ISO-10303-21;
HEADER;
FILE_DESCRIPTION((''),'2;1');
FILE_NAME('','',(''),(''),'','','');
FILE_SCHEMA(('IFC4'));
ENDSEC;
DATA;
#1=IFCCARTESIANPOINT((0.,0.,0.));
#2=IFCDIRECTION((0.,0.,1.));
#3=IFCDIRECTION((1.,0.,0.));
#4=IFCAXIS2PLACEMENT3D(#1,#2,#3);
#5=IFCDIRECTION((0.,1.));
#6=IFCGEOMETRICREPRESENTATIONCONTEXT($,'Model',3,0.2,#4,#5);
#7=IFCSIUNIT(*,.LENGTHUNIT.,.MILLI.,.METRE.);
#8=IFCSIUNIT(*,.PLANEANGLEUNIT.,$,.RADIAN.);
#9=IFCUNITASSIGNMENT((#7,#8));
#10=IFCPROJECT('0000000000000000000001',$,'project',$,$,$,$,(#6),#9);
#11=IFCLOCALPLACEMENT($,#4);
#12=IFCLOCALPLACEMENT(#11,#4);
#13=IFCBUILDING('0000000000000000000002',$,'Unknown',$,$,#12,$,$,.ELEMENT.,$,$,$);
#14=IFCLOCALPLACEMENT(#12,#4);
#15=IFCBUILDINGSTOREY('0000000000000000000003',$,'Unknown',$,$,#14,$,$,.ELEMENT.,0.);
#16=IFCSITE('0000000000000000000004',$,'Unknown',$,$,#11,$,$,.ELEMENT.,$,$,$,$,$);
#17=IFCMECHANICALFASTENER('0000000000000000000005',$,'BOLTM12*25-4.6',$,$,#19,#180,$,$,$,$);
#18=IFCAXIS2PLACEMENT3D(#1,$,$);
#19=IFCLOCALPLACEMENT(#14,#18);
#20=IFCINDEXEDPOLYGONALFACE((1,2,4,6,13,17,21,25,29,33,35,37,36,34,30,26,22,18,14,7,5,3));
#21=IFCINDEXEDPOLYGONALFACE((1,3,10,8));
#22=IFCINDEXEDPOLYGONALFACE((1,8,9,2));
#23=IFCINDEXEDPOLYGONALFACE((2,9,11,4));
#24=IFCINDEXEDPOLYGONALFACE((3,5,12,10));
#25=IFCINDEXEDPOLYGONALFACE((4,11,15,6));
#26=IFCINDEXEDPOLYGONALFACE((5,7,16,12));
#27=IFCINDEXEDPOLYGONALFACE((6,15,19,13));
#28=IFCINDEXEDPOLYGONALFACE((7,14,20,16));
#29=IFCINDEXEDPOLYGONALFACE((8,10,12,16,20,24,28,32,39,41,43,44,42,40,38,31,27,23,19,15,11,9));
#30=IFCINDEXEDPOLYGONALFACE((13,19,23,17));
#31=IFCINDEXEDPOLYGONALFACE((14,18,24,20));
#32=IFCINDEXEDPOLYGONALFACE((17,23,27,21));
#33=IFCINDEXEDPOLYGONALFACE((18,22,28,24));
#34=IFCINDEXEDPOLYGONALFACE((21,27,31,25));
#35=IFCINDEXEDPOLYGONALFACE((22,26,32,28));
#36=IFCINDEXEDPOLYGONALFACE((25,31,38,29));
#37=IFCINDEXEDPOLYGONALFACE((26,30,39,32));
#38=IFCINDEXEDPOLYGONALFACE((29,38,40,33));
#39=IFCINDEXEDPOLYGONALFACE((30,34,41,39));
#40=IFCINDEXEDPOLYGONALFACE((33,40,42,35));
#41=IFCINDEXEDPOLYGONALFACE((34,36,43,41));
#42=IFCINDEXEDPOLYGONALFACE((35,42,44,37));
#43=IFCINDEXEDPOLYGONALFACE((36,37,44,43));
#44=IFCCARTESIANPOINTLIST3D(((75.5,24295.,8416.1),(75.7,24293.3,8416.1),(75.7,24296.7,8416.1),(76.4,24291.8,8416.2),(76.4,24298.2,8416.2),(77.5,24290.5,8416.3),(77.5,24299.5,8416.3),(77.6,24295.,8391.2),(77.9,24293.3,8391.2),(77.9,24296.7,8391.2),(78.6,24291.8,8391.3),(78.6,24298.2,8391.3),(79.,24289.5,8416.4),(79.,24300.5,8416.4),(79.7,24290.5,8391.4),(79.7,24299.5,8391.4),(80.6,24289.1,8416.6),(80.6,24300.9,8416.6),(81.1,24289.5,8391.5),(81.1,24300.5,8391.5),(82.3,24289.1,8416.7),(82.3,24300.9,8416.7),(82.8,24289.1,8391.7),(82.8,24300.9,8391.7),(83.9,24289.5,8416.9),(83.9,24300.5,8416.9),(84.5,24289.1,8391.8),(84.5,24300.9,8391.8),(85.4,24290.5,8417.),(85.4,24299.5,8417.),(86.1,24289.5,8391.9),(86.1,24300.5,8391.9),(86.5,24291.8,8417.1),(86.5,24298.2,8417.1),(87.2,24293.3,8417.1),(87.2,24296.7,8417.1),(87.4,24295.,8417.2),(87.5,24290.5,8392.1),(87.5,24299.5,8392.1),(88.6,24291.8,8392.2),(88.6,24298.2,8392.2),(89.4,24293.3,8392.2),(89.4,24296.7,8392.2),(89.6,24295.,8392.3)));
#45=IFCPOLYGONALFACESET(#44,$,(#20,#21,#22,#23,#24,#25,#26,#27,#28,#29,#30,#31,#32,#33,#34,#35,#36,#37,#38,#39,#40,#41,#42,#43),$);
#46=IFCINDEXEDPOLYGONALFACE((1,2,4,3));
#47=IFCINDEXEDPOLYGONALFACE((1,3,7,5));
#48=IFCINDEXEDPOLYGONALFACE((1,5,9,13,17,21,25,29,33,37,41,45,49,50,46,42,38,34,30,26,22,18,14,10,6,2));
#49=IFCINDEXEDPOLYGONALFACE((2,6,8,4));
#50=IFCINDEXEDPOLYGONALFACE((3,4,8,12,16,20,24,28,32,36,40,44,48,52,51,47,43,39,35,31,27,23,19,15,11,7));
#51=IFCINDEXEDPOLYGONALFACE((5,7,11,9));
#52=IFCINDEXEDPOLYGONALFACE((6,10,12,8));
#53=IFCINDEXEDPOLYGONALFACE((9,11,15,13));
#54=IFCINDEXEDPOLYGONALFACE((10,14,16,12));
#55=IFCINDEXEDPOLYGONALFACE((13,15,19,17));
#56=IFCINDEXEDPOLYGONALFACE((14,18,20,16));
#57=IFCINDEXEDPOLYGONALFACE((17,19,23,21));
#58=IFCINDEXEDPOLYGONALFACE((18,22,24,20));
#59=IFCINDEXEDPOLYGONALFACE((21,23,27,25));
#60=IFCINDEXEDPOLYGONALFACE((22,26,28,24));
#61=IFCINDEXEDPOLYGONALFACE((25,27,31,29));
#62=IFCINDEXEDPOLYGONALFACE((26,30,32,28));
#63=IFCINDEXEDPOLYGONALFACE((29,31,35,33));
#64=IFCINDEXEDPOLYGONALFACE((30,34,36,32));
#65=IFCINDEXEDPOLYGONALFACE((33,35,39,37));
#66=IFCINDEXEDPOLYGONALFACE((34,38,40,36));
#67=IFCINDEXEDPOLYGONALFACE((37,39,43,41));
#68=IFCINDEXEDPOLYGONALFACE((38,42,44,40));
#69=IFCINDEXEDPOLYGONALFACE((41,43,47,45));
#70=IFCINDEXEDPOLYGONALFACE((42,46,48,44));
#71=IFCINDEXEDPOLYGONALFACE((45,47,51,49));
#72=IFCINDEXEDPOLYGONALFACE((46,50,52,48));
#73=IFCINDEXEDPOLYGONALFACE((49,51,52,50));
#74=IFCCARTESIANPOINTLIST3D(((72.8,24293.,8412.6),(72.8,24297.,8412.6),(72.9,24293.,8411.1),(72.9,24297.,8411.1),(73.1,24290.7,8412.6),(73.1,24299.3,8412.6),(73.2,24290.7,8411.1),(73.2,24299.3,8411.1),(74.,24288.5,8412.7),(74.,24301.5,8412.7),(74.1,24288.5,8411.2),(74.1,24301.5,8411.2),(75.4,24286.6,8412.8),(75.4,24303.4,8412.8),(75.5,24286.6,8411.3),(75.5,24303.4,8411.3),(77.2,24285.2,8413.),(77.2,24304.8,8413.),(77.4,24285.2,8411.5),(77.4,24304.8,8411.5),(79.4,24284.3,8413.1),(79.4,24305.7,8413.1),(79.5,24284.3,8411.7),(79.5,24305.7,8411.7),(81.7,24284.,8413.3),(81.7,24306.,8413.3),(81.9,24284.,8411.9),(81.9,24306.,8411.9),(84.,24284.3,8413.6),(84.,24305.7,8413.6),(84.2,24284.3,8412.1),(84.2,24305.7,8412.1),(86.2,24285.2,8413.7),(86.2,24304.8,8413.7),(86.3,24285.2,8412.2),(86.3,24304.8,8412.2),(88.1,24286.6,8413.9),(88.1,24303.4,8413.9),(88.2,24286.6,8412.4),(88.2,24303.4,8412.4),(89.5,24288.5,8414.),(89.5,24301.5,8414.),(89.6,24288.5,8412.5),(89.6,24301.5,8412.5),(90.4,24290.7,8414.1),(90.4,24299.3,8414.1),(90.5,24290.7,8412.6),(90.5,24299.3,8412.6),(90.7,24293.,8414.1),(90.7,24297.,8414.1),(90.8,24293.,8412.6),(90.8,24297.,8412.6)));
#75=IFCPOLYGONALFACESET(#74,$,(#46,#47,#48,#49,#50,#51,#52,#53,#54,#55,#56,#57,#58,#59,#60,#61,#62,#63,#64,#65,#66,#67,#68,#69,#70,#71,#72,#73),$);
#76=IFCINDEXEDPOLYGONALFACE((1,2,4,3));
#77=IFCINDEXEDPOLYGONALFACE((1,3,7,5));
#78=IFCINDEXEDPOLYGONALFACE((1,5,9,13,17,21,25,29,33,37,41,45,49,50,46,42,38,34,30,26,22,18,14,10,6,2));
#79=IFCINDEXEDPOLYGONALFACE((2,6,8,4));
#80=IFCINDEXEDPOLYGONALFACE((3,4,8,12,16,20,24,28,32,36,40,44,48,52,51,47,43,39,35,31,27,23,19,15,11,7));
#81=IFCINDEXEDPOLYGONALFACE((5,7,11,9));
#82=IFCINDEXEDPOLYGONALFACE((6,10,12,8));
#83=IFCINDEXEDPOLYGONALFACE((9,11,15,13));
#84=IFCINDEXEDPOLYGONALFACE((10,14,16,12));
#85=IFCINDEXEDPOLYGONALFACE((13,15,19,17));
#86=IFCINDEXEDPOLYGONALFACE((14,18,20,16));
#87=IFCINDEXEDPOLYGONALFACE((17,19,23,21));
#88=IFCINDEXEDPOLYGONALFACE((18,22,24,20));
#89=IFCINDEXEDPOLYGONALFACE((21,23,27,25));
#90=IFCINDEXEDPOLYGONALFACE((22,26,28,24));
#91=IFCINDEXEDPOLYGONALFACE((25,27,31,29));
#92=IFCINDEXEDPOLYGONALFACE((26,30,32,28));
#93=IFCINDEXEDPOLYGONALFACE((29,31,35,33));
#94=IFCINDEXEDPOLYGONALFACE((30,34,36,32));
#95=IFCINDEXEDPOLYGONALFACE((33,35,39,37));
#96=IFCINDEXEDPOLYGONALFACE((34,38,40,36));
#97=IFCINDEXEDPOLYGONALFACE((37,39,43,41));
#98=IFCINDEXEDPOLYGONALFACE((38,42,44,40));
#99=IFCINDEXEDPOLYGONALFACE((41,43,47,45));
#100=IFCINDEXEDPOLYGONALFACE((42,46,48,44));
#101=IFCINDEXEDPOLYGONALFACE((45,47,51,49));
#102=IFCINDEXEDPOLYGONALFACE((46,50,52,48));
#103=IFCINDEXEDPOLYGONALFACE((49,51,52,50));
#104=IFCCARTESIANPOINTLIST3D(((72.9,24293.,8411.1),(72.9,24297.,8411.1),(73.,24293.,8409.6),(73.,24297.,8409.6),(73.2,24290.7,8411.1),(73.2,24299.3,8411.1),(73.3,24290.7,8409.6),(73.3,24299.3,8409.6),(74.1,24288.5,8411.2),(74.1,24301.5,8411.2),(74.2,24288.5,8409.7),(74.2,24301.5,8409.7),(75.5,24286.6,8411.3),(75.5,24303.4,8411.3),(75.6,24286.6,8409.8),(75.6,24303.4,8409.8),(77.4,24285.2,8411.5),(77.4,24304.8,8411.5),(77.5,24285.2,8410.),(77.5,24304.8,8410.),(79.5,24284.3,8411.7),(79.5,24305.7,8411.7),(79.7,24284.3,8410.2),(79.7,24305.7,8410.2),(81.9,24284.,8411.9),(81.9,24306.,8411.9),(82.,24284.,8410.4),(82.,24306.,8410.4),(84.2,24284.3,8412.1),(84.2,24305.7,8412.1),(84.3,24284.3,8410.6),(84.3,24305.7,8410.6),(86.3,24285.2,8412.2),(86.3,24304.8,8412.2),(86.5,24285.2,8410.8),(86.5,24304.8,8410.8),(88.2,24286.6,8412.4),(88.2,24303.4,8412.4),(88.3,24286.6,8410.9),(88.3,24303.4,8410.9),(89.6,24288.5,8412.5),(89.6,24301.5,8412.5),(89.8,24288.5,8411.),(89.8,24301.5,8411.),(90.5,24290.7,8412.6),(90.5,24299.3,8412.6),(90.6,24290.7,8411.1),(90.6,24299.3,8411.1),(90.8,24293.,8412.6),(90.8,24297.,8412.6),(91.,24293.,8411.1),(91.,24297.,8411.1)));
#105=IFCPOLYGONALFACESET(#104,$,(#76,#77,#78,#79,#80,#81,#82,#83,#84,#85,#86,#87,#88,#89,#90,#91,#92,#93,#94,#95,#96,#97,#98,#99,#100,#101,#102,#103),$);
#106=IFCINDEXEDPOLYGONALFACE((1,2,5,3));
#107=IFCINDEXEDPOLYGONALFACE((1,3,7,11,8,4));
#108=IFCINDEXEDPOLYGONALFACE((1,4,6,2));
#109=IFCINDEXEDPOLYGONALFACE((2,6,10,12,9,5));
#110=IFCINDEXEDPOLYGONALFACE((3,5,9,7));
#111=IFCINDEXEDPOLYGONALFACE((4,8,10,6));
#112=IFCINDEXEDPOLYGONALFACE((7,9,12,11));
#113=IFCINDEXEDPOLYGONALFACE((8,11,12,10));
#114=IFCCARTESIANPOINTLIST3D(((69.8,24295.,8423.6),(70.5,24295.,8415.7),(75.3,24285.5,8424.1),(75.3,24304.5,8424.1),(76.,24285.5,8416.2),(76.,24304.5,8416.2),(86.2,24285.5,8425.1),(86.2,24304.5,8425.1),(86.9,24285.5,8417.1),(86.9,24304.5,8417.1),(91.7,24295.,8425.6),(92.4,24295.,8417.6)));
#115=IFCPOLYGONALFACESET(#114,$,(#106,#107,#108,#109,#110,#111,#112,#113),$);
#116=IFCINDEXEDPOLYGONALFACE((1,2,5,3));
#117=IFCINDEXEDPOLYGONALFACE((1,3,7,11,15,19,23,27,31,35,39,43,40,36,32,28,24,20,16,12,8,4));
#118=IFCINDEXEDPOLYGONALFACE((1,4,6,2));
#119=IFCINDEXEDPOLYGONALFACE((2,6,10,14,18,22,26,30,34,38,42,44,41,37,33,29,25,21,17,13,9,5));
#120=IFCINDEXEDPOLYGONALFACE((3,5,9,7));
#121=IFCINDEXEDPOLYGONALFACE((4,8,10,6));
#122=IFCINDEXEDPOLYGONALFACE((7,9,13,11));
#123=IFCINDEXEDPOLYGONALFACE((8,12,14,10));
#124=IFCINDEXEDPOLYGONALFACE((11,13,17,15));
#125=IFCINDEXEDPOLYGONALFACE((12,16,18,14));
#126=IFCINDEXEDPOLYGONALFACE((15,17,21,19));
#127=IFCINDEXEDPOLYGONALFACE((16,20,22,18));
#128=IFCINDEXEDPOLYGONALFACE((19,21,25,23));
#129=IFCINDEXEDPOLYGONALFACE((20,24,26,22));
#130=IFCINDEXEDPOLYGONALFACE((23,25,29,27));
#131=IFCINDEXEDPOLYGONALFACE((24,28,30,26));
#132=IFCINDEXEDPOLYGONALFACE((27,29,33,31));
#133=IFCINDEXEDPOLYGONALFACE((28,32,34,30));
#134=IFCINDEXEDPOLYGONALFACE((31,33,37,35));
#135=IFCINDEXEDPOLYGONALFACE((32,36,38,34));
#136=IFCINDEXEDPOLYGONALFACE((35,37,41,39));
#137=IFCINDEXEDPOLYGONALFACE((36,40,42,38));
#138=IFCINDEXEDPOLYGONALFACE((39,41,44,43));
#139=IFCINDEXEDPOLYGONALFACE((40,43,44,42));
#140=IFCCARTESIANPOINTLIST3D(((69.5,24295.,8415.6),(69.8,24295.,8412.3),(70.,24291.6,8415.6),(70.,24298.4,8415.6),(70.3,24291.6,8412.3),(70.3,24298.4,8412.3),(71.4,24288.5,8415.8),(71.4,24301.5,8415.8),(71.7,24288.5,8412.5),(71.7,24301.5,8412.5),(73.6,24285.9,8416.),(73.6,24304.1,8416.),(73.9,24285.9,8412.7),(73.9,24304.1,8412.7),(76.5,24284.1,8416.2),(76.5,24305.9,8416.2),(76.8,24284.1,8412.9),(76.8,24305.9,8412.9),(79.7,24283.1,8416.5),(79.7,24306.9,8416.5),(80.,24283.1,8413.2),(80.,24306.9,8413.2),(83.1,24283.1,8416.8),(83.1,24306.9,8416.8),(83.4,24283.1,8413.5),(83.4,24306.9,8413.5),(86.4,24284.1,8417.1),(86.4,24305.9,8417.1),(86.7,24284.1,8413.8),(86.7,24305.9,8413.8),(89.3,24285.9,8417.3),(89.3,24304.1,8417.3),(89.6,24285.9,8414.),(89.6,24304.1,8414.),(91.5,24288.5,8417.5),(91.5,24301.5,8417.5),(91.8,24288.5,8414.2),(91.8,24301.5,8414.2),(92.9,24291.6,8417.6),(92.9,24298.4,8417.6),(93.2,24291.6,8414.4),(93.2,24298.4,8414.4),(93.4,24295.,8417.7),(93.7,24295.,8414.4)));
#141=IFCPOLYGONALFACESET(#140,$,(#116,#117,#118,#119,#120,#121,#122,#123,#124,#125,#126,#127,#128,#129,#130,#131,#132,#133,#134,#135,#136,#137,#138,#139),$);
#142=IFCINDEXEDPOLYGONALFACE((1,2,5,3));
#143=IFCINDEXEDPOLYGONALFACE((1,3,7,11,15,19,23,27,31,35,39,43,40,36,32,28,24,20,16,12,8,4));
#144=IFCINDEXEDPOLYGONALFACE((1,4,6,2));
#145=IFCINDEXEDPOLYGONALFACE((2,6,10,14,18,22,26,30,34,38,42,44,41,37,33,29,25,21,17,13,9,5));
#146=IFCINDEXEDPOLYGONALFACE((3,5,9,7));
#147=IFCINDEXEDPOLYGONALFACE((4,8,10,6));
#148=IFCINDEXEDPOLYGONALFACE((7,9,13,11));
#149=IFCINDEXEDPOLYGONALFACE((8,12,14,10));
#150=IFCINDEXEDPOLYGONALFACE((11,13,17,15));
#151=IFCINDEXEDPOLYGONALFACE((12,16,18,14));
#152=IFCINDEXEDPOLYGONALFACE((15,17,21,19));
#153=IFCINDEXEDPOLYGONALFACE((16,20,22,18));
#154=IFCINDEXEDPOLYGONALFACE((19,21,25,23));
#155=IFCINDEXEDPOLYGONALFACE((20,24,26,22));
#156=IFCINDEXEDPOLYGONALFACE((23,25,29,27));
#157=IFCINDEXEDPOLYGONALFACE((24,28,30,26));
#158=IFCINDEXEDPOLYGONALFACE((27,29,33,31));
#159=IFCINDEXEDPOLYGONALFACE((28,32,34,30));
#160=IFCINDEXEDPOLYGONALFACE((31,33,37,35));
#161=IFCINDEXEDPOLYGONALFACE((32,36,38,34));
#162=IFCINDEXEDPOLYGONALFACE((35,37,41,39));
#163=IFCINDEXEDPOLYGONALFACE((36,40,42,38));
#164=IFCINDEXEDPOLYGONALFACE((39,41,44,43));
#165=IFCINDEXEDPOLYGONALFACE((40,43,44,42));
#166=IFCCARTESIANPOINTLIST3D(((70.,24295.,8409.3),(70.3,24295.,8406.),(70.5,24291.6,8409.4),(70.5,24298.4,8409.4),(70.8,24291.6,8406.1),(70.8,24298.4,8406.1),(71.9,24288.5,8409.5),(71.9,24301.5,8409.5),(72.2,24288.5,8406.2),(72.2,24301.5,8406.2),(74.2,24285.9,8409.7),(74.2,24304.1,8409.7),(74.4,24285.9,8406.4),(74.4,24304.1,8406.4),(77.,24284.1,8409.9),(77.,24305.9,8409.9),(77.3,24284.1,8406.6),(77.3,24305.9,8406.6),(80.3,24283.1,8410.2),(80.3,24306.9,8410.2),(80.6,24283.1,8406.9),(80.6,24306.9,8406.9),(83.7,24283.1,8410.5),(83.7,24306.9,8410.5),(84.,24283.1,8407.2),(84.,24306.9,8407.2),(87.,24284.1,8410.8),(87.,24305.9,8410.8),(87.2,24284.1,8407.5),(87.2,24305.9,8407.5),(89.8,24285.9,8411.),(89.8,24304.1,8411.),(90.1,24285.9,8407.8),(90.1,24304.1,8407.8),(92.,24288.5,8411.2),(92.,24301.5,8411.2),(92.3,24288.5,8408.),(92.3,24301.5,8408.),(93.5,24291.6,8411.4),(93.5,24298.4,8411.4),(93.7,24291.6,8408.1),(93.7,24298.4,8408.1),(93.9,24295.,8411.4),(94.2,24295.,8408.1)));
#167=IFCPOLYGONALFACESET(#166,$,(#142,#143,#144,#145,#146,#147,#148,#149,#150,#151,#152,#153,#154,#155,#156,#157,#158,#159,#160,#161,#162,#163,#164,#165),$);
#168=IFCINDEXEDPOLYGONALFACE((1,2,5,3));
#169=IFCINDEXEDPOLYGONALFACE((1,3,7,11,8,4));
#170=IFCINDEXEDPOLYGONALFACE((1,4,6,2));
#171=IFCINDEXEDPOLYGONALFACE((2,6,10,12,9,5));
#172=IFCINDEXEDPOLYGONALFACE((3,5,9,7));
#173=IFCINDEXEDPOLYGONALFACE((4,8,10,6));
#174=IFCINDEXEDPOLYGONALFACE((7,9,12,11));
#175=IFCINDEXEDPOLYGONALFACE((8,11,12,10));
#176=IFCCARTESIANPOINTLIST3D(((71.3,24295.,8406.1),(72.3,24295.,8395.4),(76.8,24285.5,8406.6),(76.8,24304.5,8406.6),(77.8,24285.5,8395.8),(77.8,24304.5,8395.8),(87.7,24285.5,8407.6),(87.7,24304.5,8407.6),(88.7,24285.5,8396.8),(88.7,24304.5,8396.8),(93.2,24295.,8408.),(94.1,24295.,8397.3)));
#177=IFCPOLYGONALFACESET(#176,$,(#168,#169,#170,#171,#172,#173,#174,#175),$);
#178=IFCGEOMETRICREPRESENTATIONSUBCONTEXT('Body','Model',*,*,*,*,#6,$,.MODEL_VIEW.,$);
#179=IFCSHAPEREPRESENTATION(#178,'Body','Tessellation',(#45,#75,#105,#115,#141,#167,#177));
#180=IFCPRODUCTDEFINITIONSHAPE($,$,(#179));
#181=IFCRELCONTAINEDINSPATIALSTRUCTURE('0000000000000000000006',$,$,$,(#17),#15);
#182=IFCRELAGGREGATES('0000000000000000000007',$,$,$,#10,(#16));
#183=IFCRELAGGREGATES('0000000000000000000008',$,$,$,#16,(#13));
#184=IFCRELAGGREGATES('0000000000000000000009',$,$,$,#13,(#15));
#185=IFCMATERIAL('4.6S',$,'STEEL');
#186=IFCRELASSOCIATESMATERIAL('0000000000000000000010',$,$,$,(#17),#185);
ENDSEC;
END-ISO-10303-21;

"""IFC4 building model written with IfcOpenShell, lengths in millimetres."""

from ifc_helpers import new_model, si_unit, direction, frame, origin_with_axes, place, context, subcontext, project, spatial, line, arc, indexed_curve, outline, extrude, source, transform, mapped, material, element, save


model = new_model("IFC4")

# Units and contexts
model_context = context("Model", 3, precision=0.2, world=origin_with_axes(), true_north=direction((0.0, 1.0)))
body_context = subcontext(model_context, "Body", "Model", "MODEL_VIEW")
ifc_project = project(units=[si_unit("LENGTHUNIT", "METRE", prefix="MILLI"), si_unit("PLANEANGLEUNIT", "RADIAN")], contexts=[model_context])

# Site, building, storey
site_placement = place(None, origin_with_axes())
site = spatial("IfcSite", under=ifc_project, at=site_placement, Name="Unknown", CompositionType="ELEMENT")
building_placement = place(site_placement, origin_with_axes())
building = spatial("IfcBuilding", under=site, at=building_placement, Name="Unknown", CompositionType="ELEMENT")
storey_placement = place(building_placement, origin_with_axes())
storey = spatial("IfcBuildingStorey", under=building, at=storey_placement, Name="Unknown", CompositionType="ELEMENT", Elevation=0.0)

# Mechanical fastener
ifc_material_1 = material(Name="4.6S", Category="STEEL")
shared_shape_1 = source(origin_with_axes(), body_context, "Body", "SweptSolid", [
    extrude(outline(indexed_curve([(6.0, 0.0), (0.0, 6.0), (-6.0, 0.0), (0.0, -6.0)], segments=[arc(1, 2, 3), arc(3, 4, 1)])), frame((0.0, 0.0, 4.8), z_axis=(0.0, 0.0, -1.0), x_axis=(0.0, 1.0, 0.0)), (0.0, 0.0, 1.0), 25.0),
    extrude(outline(indexed_curve([(0.0, 11.0), (6.4, 8.4), (9.0, 2.0), (9.0, -2.0), (6.4, -8.4), (0.0, -11.0), (-0.8, -11.0), (-9.0, -2.0), (-9.0, 2.0), (-6.4, 8.4)], segments=[arc(1, 2, 3), line(3, 4), arc(4, 5, 6), arc(6, 7, 8), line(8, 9), arc(9, 10, 1)])), frame((0.0, 0.0, 1.5), z_axis=(0.0, 0.0, -1.0), x_axis=(0.0, 1.0, 0.0)), (0.0, 0.0, 1.0), 1.5),
    extrude(outline(indexed_curve([(0.0, 11.0), (6.4, 8.4), (9.0, 2.0), (9.0, -2.0), (6.4, -8.4), (0.0, -11.0), (-0.8, -11.0), (-9.0, -2.0), (-9.0, 2.0), (-6.4, 8.4)], segments=[arc(1, 2, 3), line(3, 4), arc(4, 5, 6), arc(6, 7, 8), line(8, 9), arc(9, 10, 1)])), frame((0.0, 0.0, 0.0), z_axis=(0.0, 0.0, -1.0), x_axis=(0.0, 1.0, 0.0)), (0.0, 0.0, 1.0), 1.5),
    extrude(outline(indexed_curve([(11.0, 0.0), (5.5, 9.5), (-5.5, 9.5), (-11.0, 0.0), (-5.5, -9.5), (5.5, -9.5)], segments=[line(1, 2, 3, 4, 5, 6, 1)])), frame((0.0, 0.0, 12.8), z_axis=(0.0, 0.0, -1.0), x_axis=(0.0, 1.0, 0.0)), (0.0, 0.0, 1.0), 8.0),
    extrude(outline(indexed_curve([(12.0, 0.0), (0.0, 12.0), (-12.0, 0.0), (0.0, -12.0)], segments=[arc(1, 2, 3), arc(3, 4, 1)])), frame((0.0, 0.0, 4.8), z_axis=(0.0, 0.0, -1.0), x_axis=(0.0, 1.0, 0.0)), (0.0, 0.0, 1.0), 3.3),
    extrude(outline(indexed_curve([(12.0, 0.0), (0.0, 12.0), (-12.0, 0.0), (0.0, -12.0)], segments=[arc(1, 2, 3), arc(3, 4, 1)])), frame((0.0, 0.0, -1.5), z_axis=(0.0, 0.0, -1.0), x_axis=(0.0, 1.0, 0.0)), (0.0, 0.0, 1.0), 3.3),
    extrude(outline(indexed_curve([(11.0, 0.0), (5.5, 9.5), (-5.5, 9.5), (-11.0, 0.0), (-5.5, -9.5), (5.5, -9.5)], segments=[line(1, 2, 3, 4, 5, 6, 1)])), frame((0.0, 0.0, -4.8), z_axis=(0.0, 0.0, -1.0), x_axis=(0.0, 1.0, 0.0)), (0.0, 0.0, 1.0), 10.8),
])
for number, where, z_axis, x_axis, name in (
    (1, (81.9, 24295.0, 8411.9), (-0.08716, 0.0, 0.996194), (0.0, 1.0, 0.0), "BOLTM12*25-4.6"),
):
    element("IfcMechanicalFastener", number, at=place(storey_placement, frame(where, z_axis=z_axis, x_axis=x_axis)), inside=storey, material=ifc_material_1, Name=name, context=body_context, shape_type="MappedRepresentation", body=[
        mapped(shared_shape_1, transform((0.0, 0.0, 0.0))),
    ])

save(model, "model.ifc")
